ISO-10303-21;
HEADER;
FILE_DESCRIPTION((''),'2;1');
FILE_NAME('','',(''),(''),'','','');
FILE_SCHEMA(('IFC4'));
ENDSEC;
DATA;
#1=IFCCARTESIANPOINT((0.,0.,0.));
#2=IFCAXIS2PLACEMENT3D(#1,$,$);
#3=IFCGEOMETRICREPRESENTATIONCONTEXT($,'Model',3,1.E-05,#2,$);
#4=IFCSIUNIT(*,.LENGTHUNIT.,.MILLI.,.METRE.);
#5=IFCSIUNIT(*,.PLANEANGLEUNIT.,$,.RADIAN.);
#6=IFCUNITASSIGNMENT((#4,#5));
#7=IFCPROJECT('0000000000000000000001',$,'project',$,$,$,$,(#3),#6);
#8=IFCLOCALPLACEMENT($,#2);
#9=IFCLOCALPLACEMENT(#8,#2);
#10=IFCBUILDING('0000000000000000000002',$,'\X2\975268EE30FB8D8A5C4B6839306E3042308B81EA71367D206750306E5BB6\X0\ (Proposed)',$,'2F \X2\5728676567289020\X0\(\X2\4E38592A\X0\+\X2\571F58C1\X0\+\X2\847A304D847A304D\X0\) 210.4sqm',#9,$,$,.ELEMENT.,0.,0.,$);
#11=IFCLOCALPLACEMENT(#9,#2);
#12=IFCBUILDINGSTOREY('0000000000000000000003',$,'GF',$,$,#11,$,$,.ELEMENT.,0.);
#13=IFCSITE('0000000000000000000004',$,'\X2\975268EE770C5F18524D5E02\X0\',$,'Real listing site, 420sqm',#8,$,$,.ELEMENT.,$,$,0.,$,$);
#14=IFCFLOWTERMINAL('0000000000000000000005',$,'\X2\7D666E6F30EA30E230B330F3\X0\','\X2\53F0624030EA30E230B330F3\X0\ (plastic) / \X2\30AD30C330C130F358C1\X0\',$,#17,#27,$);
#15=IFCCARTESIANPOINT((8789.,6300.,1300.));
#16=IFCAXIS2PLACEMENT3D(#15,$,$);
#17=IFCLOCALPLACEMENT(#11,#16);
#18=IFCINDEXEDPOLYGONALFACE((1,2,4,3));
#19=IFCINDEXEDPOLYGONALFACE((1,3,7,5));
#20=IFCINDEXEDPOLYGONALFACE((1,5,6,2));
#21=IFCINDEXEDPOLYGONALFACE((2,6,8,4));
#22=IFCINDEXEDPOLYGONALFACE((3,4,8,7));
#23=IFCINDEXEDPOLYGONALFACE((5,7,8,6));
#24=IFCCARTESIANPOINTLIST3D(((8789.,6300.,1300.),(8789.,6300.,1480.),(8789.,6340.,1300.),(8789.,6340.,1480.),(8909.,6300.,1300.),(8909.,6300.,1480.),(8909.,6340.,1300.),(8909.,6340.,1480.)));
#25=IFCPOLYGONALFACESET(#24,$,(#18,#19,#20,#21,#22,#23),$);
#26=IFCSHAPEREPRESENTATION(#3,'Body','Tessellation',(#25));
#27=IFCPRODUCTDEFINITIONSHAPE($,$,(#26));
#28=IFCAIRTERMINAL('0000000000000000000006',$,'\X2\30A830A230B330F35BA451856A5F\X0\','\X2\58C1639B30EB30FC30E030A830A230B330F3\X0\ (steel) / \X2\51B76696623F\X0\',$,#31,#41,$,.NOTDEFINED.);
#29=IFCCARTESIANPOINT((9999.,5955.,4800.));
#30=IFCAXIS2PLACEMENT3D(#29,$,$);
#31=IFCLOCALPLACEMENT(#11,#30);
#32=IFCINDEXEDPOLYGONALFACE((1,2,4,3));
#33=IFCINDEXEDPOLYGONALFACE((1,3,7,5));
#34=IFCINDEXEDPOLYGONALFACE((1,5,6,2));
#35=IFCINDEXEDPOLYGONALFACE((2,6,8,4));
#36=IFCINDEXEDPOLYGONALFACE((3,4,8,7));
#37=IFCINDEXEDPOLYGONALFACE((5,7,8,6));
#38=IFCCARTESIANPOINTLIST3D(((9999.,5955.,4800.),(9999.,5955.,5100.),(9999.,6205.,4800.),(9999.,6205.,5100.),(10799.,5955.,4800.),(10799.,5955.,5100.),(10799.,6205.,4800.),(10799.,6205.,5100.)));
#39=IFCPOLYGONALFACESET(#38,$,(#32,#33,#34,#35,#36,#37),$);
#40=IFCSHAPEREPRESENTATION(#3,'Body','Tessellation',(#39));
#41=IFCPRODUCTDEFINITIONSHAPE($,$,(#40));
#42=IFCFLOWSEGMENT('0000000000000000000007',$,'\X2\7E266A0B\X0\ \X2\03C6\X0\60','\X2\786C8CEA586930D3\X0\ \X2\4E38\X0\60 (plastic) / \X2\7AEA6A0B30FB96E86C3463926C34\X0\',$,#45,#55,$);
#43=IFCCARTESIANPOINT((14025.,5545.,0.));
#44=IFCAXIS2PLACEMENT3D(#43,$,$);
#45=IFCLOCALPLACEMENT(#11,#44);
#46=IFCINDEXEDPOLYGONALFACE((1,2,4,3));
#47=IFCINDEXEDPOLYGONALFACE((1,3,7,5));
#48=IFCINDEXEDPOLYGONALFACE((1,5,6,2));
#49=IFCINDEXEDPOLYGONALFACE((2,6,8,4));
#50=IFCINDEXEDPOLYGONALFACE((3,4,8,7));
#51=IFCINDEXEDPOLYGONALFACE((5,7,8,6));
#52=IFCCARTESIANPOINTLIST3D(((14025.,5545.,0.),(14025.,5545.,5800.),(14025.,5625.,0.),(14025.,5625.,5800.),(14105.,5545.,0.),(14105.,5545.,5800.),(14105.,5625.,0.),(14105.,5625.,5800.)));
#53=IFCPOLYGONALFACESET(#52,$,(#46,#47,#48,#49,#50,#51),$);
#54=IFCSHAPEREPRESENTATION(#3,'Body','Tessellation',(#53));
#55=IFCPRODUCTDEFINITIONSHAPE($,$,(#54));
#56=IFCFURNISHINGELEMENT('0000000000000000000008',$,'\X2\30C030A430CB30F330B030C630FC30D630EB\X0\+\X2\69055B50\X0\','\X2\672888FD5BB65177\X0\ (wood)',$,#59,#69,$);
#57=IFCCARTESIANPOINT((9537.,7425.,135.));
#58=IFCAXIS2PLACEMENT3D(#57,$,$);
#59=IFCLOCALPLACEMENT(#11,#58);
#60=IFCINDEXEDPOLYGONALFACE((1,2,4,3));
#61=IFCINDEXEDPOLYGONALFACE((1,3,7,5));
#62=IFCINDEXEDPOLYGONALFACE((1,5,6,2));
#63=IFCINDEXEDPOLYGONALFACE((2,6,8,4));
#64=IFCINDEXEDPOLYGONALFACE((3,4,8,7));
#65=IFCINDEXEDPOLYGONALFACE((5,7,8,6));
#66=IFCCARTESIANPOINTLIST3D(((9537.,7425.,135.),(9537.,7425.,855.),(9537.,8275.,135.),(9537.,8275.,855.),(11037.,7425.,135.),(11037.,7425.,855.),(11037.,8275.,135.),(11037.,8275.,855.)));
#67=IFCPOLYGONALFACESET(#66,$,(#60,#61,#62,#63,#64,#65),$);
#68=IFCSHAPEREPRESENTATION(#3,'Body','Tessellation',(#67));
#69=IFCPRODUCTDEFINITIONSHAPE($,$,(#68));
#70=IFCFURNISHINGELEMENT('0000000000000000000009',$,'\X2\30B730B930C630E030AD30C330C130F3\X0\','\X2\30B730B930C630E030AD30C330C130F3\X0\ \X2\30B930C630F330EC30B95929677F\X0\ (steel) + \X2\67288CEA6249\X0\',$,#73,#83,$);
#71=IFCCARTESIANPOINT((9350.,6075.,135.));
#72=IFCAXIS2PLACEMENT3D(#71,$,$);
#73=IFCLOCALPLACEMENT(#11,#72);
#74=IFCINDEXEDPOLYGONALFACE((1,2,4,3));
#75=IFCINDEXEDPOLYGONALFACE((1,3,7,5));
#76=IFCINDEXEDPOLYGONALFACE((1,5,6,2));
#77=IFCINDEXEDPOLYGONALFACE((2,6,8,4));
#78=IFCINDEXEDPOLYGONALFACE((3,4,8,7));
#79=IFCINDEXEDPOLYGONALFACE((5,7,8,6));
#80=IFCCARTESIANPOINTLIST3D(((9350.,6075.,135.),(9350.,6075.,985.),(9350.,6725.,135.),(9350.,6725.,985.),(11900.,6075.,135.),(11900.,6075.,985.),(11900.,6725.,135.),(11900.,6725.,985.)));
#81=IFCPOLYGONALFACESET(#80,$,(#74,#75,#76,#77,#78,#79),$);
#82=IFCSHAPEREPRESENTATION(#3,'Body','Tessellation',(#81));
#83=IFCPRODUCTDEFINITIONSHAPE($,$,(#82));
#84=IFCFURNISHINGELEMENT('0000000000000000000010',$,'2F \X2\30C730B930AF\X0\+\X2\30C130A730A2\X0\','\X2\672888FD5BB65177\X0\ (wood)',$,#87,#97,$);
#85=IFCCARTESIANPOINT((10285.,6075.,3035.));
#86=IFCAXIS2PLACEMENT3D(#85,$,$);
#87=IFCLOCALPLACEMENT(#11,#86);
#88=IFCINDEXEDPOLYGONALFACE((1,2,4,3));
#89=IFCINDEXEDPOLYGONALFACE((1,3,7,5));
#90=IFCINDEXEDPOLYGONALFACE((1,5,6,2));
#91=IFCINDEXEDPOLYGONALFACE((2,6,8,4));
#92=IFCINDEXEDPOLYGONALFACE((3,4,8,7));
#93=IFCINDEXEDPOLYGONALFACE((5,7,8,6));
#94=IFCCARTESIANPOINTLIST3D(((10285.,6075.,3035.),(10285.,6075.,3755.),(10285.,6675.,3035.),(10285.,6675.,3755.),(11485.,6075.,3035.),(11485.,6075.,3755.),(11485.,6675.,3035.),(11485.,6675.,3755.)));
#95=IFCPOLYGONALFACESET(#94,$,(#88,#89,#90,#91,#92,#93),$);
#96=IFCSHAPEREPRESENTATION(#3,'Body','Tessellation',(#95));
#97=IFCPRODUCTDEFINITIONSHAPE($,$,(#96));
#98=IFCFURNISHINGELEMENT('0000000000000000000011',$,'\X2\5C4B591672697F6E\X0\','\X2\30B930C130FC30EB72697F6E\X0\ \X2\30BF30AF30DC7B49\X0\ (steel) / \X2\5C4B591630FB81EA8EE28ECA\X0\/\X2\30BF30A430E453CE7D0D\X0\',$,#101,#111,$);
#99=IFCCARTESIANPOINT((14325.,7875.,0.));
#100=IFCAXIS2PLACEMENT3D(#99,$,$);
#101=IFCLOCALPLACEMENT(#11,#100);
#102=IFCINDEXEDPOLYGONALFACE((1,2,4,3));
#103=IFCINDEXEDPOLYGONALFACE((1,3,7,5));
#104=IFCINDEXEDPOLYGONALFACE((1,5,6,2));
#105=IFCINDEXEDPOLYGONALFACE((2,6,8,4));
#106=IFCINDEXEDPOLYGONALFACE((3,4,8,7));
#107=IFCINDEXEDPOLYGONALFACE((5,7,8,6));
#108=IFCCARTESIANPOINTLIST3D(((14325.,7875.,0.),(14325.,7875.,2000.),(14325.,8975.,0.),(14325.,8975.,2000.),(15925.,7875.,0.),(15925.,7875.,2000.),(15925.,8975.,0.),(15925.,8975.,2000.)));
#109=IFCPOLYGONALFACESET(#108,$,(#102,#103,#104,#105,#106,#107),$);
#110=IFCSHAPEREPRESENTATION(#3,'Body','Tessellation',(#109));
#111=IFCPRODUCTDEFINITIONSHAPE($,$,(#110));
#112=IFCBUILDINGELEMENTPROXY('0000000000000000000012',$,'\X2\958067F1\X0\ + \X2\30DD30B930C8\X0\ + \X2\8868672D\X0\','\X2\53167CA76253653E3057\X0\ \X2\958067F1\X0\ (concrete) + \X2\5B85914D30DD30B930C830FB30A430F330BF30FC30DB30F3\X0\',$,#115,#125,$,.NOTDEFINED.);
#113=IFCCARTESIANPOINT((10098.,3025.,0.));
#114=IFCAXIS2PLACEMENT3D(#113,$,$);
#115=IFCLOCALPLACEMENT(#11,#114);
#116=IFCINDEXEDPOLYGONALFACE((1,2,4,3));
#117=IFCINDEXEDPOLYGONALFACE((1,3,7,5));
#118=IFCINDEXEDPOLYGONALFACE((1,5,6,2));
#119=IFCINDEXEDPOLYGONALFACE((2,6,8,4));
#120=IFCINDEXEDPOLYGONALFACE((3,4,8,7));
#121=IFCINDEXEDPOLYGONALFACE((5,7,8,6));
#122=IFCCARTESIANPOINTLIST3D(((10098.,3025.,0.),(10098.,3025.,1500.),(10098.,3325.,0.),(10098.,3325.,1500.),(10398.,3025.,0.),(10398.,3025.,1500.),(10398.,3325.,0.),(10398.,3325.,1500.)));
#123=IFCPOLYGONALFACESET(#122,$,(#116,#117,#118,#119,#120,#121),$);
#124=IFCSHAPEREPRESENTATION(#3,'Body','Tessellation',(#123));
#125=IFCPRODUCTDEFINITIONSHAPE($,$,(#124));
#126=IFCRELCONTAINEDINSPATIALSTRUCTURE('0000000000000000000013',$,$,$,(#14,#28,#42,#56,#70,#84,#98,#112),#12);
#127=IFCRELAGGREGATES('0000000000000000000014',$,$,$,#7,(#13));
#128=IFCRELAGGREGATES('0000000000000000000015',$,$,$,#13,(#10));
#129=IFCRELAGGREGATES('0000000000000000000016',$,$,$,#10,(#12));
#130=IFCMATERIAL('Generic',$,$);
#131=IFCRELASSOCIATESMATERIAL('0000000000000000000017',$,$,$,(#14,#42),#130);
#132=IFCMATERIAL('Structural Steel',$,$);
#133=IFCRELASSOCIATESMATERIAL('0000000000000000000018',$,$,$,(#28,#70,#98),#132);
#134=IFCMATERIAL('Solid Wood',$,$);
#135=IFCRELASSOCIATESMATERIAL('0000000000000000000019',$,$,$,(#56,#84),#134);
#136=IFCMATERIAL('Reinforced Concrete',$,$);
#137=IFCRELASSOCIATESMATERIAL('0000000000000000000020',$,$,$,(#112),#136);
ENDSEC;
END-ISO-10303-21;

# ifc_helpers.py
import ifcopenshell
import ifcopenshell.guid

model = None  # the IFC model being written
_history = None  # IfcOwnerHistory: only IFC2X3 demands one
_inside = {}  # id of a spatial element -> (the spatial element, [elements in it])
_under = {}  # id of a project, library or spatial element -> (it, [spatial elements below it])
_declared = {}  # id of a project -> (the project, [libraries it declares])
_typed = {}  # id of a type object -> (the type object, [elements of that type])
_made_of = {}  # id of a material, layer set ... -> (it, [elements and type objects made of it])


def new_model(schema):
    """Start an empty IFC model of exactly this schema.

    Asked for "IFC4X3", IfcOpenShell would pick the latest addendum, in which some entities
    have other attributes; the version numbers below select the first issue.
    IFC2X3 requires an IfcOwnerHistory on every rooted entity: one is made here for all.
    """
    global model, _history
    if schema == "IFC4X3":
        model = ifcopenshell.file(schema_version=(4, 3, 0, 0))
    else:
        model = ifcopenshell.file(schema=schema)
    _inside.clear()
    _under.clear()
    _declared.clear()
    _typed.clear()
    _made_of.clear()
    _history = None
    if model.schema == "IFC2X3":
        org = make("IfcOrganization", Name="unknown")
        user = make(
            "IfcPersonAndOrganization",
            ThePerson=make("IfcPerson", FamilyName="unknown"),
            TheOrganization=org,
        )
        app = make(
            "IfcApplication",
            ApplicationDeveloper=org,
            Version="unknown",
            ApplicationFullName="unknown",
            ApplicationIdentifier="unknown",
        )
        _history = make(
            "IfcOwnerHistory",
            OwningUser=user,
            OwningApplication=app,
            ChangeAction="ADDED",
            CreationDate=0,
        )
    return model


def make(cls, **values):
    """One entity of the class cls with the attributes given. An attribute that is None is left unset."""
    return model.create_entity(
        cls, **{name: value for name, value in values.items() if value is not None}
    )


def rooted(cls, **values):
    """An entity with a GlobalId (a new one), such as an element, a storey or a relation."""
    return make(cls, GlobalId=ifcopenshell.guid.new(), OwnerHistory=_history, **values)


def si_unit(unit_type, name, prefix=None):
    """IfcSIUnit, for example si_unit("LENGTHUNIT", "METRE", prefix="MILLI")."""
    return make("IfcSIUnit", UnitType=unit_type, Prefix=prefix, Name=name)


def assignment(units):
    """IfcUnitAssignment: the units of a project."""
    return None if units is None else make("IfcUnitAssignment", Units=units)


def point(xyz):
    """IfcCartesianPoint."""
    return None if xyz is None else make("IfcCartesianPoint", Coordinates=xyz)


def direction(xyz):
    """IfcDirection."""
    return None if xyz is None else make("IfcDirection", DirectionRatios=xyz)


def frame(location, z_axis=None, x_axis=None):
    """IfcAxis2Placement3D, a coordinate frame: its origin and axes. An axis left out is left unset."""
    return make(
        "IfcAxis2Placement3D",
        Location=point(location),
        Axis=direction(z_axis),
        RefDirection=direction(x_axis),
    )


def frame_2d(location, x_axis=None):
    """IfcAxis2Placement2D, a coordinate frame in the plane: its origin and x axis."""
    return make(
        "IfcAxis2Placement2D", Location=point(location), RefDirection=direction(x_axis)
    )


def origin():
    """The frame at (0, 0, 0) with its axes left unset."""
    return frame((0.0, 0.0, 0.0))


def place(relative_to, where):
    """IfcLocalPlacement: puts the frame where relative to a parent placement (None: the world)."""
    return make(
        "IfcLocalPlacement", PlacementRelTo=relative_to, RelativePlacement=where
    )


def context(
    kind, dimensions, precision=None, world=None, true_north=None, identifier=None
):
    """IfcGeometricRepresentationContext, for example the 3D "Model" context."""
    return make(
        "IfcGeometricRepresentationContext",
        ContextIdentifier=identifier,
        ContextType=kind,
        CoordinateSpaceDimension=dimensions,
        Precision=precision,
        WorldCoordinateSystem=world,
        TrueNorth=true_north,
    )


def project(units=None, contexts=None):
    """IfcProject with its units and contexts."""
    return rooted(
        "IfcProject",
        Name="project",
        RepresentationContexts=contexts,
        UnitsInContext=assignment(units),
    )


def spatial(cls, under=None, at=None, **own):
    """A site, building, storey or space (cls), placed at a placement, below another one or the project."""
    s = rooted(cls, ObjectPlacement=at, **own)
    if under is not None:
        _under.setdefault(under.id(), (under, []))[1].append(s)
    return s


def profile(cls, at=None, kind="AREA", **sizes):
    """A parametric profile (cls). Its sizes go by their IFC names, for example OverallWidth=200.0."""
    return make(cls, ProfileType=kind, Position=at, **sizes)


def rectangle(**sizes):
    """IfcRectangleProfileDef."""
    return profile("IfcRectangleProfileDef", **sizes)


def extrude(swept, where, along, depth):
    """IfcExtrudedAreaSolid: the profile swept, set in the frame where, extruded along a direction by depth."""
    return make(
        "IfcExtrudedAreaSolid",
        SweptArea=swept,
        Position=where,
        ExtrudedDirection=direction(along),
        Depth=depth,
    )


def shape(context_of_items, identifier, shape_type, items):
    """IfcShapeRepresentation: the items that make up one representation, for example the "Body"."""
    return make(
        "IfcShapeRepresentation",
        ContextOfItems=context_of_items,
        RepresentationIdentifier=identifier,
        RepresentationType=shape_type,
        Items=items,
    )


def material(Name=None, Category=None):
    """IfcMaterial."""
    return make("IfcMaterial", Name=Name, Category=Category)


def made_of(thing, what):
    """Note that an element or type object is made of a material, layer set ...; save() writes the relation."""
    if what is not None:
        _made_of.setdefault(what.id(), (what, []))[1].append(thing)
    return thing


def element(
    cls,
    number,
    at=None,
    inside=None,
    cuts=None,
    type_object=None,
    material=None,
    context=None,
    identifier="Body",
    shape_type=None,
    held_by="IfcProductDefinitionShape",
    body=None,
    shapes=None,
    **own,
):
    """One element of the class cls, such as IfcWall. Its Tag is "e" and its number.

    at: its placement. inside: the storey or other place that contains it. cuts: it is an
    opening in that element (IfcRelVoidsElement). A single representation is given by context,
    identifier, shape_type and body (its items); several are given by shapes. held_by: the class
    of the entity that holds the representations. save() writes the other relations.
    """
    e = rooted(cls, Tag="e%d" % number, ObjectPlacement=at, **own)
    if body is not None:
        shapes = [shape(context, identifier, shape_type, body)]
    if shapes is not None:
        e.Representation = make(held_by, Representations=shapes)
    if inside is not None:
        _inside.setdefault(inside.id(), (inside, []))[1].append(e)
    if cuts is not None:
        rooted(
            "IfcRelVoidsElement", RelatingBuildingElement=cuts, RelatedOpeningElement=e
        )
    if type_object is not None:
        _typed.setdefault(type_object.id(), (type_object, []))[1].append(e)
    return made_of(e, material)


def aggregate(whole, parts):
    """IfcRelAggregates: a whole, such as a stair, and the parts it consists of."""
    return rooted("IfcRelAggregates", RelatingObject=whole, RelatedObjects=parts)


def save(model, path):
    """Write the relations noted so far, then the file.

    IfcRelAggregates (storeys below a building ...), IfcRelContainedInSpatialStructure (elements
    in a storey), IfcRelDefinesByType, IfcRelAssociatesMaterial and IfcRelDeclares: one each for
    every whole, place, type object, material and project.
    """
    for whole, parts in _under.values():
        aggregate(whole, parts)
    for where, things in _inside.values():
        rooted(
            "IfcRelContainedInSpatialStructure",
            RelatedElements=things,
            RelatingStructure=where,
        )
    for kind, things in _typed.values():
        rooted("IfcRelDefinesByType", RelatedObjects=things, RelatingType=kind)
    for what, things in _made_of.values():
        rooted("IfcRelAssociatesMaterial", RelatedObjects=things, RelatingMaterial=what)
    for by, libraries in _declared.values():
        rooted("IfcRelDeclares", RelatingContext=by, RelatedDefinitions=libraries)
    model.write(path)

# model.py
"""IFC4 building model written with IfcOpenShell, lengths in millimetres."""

from ifc_helpers import new_model, si_unit, frame, frame_2d, origin, place, context, project, spatial, rectangle, extrude, material, element, save


model = new_model("IFC4")

# Units and contexts
model_context = context("Model", 3, precision=1e-05, world=origin())
ifc_project = project(units=[si_unit("LENGTHUNIT", "METRE", prefix="MILLI"), si_unit("PLANEANGLEUNIT", "RADIAN")], contexts=[model_context])

# Site, building, storey
site_placement = place(None, origin())
site = spatial("IfcSite", under=ifc_project, at=site_placement, Name="青森県弘前市", ObjectType="Real listing site, 420sqm", CompositionType="ELEMENT", RefElevation=0.0)
building_placement = place(site_placement, origin())
building = spatial("IfcBuilding", under=site, at=building_placement, Name="青森・越屋根のある自然素材の家 (Proposed)", ObjectType="2F 在来木造(丸太+土壁+葺き葺き) 210.4sqm", CompositionType="ELEMENT", ElevationOfRefHeight=0.0, ElevationOfTerrain=0.0)
storey_placement = place(building_placement, origin())
storey = spatial("IfcBuildingStorey", under=building, at=storey_placement, Name="GF", CompositionType="ELEMENT", Elevation=0.0)

# Shared definitions
ifc_material_1 = material(Name="Solid Wood")

# Shared definitions
ifc_material_2 = material(Name="Reinforced Concrete")

# Shared definitions
ifc_material_3 = material(Name="Structural Steel")

# Flow terminal
ifc_material_4 = material(Name="Generic")
flow_terminal_1_placement = place(storey_placement, frame((8789.0, 6300.0, 1300.0)))
element("IfcFlowTerminal", 1, at=flow_terminal_1_placement, inside=storey, material=ifc_material_4, Name="給湯リモコン", Description="台所リモコン (plastic) / キッチン壁", context=model_context, shape_type="SweptSolid", body=[
    extrude(rectangle(XDim=120.0, YDim=40.0, at=frame_2d((60.0, 20.0))), frame((8789.0, 6300.0, 1300.0)), (0.0, 0.0, 1.0), 180.0),
])

# Air terminal
air_terminal_placement = place(storey_placement, frame((9999.0, 5955.0, 4800.0)))
element("IfcAirTerminal", 2, at=air_terminal_placement, inside=storey, material=ifc_material_3, Name="エアコン室内機", Description="壁掛ルームエアコン (steel) / 冷暖房", PredefinedType="NOTDEFINED", context=model_context, shape_type="SweptSolid", body=[
    extrude(rectangle(XDim=800.0, YDim=250.0, at=frame_2d((400.0, 125.0))), frame((9999.0, 5955.0, 4800.0)), (0.0, 0.0, 1.0), 300.0),
])

# Flow segment
flow_segment_placement = place(storey_placement, frame((14025.0, 5545.0, 0.0)))
element("IfcFlowSegment", 3, at=flow_segment_placement, inside=storey, material=ifc_material_4, Name="縦樋 φ60", Description="硬質塩ビ 丸60 (plastic) / 竪樋・雨水排水", context=model_context, shape_type="SweptSolid", body=[
    extrude(rectangle(XDim=80.0, YDim=80.0, at=frame_2d((40.0, 40.0))), frame((14025.0, 5545.0, 0.0)), (0.0, 0.0, 1.0), 5800.0),
])

# Furnishing elements
furnishing_1_placement = place(storey_placement, frame((9537.0, 7425.0, 135.0)))
element("IfcFurnishingElement", 4, at=furnishing_1_placement, inside=storey, material=ifc_material_1, Name="ダイニングテーブル+椅子", Description="木製家具 (wood)", context=model_context, shape_type="SweptSolid", body=[
    extrude(rectangle(XDim=1500.0, YDim=850.0, at=frame_2d((750.0, 425.0))), frame((9537.0, 7425.0, 135.0)), (0.0, 0.0, 1.0), 720.0),
])
furnishing_2_placement = place(storey_placement, frame((9350.0, 6075.0, 135.0)))
element("IfcFurnishingElement", 5, at=furnishing_2_placement, inside=storey, material=ifc_material_3, Name="システムキッチン", Description="システムキッチン ステンレス天板 (steel) + 木質扉", context=model_context, shape_type="SweptSolid", body=[
    extrude(rectangle(XDim=2550.0, YDim=650.0, at=frame_2d((1275.0, 325.0))), frame((9350.0, 6075.0, 135.0)), (0.0, 0.0, 1.0), 850.0),
])
furnishing_3_placement = place(storey_placement, frame((10285.0, 6075.0, 3035.0)))
element("IfcFurnishingElement", 6, at=furnishing_3_placement, inside=storey, material=ifc_material_1, Name="2F デスク+チェア", Description="木製家具 (wood)", context=model_context, shape_type="SweptSolid", body=[
    extrude(rectangle(XDim=1200.0, YDim=600.0, at=frame_2d((600.0, 300.0))), frame((10285.0, 6075.0, 3035.0)), (0.0, 0.0, 1.0), 720.0),
])
furnishing_4_placement = place(storey_placement, frame((14325.0, 7875.0, 0.0)))
element("IfcFurnishingElement", 7, at=furnishing_4_placement, inside=storey, material=ifc_material_3, Name="屋外物置", Description="スチール物置 タクボ等 (steel) / 屋外・自転車/タイヤ収納", context=model_context, shape_type="SweptSolid", body=[
    extrude(rectangle(XDim=1600.0, YDim=1100.0, at=frame_2d((800.0, 550.0))), frame((14325.0, 7875.0, 0.0)), (0.0, 0.0, 1.0), 2000.0),
])

# Building element proxy
proxy_placement = place(storey_placement, frame((10098.0, 3025.0, 0.0)))
element("IfcBuildingElementProxy", 8, at=proxy_placement, inside=storey, material=ifc_material_2, Name="門柱 + ポスト + 表札", Description="化粧打放し 門柱 (concrete) + 宅配ポスト・インターホン", PredefinedType="NOTDEFINED", context=model_context, shape_type="SweptSolid", body=[
    extrude(rectangle(XDim=300.0, YDim=300.0, at=frame_2d((150.0, 150.0))), frame((10098.0, 3025.0, 0.0)), (0.0, 0.0, 1.0), 1500.0),
])

save(model, "model.ifc")
